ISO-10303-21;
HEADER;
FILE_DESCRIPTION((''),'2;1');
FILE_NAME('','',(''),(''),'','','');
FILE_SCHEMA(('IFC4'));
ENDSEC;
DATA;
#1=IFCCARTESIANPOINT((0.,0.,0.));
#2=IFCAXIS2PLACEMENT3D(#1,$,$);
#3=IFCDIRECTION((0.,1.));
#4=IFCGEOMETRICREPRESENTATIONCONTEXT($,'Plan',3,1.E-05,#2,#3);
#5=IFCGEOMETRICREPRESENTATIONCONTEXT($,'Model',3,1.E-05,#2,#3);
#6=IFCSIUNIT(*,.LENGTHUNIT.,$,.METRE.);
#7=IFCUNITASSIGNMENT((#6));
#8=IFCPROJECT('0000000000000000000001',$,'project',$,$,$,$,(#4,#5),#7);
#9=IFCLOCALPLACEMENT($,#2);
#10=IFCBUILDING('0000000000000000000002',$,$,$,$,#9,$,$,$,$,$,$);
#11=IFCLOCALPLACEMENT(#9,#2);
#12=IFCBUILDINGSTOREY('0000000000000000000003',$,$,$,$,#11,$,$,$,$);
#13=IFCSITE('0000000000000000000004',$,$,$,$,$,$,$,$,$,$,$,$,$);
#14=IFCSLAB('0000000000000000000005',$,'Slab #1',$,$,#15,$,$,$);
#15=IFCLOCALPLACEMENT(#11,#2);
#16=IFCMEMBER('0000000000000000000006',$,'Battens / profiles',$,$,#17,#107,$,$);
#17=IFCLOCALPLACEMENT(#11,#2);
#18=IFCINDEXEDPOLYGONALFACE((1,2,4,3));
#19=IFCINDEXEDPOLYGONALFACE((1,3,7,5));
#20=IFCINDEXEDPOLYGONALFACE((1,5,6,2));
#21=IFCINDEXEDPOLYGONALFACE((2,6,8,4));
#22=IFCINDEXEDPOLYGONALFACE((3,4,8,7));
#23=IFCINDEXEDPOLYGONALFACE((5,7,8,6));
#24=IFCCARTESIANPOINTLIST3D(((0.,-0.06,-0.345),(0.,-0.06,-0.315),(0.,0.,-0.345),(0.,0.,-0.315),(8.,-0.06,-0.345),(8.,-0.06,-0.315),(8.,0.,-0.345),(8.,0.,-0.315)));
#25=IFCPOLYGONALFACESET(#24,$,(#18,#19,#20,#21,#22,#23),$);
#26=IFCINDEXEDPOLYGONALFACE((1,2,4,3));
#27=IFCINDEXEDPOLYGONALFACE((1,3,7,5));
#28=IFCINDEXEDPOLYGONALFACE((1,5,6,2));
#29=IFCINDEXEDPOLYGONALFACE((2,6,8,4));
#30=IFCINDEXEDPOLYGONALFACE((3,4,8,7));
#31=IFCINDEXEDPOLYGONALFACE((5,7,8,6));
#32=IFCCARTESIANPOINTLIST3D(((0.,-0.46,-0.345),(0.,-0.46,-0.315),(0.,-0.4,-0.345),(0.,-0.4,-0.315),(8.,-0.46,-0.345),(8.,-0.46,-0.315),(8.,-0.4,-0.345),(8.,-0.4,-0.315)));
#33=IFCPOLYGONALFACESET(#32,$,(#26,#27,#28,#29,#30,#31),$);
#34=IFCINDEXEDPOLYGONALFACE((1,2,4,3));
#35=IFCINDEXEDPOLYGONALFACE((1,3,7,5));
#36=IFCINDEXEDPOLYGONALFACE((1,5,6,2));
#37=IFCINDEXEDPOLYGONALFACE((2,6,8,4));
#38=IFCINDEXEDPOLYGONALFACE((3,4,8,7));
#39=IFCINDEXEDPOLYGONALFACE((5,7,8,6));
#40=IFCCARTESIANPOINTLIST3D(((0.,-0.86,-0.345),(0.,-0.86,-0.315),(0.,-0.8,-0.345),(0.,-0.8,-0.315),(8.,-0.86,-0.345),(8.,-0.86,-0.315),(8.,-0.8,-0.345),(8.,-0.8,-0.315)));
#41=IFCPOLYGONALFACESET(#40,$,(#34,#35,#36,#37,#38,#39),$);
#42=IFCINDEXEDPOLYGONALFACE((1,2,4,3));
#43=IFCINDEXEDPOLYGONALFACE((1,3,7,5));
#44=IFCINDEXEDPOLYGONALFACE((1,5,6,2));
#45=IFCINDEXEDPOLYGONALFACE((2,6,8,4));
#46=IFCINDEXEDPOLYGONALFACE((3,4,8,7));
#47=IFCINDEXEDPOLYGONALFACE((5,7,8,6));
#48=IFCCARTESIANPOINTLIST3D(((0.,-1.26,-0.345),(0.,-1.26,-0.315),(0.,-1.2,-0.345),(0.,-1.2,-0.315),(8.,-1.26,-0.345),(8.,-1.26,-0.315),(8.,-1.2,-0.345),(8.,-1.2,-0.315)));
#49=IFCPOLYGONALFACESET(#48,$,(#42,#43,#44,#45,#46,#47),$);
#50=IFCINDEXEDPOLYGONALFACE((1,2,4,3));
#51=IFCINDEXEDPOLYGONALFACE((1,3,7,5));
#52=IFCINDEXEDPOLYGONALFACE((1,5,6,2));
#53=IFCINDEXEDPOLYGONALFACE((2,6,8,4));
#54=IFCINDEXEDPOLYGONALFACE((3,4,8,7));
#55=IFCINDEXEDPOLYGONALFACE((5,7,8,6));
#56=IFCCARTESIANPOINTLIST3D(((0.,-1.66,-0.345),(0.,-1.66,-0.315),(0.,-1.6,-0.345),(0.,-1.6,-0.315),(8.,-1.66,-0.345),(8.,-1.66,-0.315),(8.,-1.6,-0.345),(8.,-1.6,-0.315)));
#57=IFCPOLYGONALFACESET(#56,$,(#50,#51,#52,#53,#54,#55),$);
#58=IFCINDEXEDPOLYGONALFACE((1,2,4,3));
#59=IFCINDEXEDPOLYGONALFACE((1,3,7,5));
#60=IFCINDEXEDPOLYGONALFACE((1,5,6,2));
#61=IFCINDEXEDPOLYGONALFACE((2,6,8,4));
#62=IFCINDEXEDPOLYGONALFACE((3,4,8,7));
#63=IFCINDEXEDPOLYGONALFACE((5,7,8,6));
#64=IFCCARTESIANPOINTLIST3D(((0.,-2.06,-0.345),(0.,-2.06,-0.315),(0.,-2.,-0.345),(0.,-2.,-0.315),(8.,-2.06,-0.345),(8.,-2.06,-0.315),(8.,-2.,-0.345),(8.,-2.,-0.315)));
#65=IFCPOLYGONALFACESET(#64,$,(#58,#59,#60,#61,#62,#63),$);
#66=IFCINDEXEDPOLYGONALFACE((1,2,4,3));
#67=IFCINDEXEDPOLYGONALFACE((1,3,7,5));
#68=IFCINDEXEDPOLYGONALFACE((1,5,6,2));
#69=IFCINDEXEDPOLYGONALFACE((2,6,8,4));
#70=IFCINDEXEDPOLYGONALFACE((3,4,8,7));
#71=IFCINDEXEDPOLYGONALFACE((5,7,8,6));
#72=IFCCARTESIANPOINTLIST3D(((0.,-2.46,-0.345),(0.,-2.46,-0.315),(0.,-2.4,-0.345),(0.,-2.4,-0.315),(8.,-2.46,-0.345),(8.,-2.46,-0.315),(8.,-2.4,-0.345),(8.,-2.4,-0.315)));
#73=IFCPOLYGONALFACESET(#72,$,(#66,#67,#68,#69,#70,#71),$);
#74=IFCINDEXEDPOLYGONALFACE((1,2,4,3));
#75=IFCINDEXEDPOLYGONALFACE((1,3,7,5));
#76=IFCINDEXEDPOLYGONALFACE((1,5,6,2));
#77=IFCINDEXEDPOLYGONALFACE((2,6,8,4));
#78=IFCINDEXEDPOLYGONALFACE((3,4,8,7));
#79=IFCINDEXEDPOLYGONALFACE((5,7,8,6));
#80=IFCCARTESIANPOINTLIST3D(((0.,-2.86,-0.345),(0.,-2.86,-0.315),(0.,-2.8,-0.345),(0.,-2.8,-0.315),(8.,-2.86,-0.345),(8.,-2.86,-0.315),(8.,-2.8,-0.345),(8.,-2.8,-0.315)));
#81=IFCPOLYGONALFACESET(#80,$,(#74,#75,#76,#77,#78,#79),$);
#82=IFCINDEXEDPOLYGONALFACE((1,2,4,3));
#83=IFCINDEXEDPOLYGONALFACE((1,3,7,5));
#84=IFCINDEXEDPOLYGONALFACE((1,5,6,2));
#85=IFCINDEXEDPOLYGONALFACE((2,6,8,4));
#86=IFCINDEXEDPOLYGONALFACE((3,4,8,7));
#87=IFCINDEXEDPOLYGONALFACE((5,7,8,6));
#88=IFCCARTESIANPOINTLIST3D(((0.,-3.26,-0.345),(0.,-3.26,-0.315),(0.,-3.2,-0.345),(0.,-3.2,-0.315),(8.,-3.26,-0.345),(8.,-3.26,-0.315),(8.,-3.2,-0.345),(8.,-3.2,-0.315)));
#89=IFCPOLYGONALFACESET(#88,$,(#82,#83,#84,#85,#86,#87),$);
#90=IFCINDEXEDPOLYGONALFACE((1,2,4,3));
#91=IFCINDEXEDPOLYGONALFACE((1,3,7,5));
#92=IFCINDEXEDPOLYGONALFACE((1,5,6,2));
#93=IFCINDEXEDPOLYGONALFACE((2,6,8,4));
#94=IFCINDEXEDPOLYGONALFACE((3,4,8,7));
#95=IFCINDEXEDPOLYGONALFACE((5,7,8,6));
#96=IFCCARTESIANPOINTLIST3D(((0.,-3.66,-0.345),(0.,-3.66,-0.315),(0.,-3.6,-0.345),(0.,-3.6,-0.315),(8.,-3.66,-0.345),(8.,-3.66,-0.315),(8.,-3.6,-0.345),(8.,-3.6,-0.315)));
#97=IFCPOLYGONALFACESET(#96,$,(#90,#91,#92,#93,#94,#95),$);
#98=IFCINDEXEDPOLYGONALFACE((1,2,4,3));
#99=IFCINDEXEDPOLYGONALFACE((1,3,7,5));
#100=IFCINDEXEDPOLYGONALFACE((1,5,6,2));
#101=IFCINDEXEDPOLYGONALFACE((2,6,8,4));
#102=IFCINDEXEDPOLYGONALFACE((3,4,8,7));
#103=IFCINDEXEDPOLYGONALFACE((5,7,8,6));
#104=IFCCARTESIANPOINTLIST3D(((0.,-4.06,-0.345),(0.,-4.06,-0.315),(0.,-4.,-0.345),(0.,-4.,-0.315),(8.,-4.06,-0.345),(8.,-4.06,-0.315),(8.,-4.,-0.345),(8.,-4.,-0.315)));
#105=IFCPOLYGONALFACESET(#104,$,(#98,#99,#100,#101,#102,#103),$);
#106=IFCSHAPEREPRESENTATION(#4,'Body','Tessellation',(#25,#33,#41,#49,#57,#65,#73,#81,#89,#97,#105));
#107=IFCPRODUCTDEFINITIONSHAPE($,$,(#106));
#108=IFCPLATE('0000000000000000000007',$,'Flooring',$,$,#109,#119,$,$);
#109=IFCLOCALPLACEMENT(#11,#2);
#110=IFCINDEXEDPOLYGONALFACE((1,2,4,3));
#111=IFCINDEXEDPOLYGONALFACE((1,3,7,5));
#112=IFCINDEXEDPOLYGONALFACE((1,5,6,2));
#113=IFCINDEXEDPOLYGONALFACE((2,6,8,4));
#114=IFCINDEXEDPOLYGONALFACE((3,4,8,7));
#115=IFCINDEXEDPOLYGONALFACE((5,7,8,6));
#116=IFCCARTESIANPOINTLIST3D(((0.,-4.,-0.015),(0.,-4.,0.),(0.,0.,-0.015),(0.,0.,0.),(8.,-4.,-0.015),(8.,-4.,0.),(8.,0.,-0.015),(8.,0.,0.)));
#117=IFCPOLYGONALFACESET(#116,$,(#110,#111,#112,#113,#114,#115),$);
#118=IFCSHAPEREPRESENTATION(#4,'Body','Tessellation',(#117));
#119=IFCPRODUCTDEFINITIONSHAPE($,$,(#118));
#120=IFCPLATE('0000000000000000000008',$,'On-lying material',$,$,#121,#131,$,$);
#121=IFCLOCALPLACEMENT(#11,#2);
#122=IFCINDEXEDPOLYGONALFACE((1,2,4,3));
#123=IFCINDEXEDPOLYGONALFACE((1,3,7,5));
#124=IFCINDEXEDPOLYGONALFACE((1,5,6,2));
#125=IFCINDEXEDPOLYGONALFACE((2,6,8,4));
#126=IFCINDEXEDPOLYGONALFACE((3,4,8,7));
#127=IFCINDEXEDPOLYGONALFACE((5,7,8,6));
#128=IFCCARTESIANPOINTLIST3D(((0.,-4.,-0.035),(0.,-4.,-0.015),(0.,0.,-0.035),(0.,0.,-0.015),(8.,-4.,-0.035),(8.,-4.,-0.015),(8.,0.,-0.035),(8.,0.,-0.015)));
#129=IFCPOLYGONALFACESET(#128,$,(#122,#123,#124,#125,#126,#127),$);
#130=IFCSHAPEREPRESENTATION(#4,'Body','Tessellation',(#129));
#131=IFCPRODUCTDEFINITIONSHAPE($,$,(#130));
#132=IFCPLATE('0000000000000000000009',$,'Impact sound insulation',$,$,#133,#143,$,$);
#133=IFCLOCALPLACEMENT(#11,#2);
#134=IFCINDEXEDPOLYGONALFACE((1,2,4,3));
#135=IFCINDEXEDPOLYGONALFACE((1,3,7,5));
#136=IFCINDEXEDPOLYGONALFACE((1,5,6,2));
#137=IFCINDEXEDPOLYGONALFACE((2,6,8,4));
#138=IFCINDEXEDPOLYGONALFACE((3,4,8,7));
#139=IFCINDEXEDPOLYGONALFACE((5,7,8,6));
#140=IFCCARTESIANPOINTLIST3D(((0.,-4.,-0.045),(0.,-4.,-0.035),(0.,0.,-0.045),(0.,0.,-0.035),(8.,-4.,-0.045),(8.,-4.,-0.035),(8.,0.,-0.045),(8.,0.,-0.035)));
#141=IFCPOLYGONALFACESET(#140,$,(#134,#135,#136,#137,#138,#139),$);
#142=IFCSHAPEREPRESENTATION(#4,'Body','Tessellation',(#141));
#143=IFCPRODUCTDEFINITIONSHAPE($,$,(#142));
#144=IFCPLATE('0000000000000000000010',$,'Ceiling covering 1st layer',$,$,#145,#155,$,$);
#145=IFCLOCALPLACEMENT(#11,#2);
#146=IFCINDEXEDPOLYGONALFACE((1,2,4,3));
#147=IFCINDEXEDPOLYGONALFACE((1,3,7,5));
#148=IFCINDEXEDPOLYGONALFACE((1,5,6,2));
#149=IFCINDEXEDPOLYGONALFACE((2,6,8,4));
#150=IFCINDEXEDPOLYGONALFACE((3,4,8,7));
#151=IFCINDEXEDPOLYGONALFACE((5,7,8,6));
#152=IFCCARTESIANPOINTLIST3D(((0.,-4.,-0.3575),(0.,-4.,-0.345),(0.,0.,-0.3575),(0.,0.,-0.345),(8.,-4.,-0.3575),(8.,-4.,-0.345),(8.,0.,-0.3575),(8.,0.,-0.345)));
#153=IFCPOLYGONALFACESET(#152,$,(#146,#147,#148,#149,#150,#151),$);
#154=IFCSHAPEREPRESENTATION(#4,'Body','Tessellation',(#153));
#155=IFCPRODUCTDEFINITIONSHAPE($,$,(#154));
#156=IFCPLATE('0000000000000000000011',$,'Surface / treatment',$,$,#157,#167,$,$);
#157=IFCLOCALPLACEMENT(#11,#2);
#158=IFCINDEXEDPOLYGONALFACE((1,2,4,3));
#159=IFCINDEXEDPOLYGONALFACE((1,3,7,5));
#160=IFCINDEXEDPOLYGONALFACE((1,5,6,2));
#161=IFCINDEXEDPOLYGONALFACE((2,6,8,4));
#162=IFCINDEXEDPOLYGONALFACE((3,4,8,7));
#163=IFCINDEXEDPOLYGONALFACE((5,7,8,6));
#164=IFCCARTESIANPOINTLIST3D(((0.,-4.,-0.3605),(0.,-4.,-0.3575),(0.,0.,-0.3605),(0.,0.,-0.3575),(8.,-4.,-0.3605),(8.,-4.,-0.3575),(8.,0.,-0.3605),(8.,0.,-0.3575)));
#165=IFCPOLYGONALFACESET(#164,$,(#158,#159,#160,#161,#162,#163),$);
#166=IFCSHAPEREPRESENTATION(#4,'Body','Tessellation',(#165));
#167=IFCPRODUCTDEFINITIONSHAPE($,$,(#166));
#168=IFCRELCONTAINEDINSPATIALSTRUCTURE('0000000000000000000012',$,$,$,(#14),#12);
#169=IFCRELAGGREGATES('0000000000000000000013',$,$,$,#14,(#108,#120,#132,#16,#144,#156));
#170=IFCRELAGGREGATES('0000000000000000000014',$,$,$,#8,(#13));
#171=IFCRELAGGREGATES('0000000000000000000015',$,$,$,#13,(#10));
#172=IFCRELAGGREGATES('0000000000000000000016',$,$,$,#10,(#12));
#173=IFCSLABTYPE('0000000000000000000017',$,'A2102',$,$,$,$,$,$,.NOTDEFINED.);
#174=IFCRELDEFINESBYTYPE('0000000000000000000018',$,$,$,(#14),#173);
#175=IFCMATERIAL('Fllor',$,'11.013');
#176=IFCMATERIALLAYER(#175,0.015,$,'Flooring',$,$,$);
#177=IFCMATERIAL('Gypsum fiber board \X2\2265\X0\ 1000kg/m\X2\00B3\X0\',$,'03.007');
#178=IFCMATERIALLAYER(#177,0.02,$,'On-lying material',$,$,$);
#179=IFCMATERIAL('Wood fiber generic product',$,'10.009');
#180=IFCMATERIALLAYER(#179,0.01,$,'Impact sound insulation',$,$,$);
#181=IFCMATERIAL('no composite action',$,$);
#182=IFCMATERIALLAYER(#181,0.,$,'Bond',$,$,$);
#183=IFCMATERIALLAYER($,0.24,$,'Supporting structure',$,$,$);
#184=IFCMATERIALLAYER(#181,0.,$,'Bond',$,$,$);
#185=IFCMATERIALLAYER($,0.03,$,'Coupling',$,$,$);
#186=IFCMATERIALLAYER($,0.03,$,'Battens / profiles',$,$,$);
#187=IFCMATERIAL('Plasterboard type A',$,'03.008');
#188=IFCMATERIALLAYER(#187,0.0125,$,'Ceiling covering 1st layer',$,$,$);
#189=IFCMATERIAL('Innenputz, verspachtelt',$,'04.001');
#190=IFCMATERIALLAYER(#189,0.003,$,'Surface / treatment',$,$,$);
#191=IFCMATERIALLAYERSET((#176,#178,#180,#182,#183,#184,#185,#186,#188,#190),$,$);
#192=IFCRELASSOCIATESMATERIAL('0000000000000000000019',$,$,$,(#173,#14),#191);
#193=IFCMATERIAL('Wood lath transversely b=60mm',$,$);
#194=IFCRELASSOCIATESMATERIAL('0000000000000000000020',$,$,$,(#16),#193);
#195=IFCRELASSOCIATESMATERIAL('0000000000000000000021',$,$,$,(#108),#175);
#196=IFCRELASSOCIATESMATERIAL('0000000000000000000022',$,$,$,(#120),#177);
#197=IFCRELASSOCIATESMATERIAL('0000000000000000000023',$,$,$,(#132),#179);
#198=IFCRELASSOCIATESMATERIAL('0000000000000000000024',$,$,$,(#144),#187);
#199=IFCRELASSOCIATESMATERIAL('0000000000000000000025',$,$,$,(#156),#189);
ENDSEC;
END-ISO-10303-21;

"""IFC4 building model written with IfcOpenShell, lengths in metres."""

from ifc_helpers import new_model, si_unit, direction, frame, frame_2d, origin, origin_with_axes, place, context, project, spatial, rectangle, extrude, material, layer, layer_set, type_object, element, aggregate, save


model = new_model("IFC4")

# Units and contexts
plan_context = context("Plan", 3, precision=1e-05, world=origin(), true_north=direction((0.0, 1.0)))
model_context = context("Model", 3, precision=1e-05, world=origin(), true_north=direction((0.0, 1.0)))
ifc_project = project(units=[si_unit("LENGTHUNIT", "METRE")], contexts=[plan_context, model_context])

# Site, building, storey
site = spatial("IfcSite", under=ifc_project)
building_placement = place(None, origin())
building = spatial("IfcBuilding", under=site, at=building_placement)
storey_placement = place(building_placement, origin())
storey = spatial("IfcBuildingStorey", under=building, at=storey_placement)

# Slab, member, plates
ifc_material_1 = material(Name="Fllor", Category="11.013")
ifc_layer_1 = layer(ifc_material_1, 0.015, Name="Flooring")
ifc_material_2 = material(Name="Gypsum fiber board ≥ 1000kg/m³", Category="03.007")
ifc_layer_2 = layer(ifc_material_2, 0.02, Name="On-lying material")
ifc_material_3 = material(Name="Wood fiber generic product", Category="10.009")
ifc_layer_3 = layer(ifc_material_3, 0.01, Name="Impact sound insulation")
ifc_material_4 = material(Name="no composite action")
ifc_layer_4 = layer(ifc_material_4, 0.0, Name="Bond")
ifc_layer_5 = layer(None, 0.24, Name="Supporting structure")
ifc_layer_6 = layer(ifc_material_4, 0.0, Name="Bond")
ifc_layer_7 = layer(None, 0.03, Name="Coupling")
ifc_layer_8 = layer(None, 0.03, Name="Battens / profiles")
ifc_material_5 = material(Name="Plasterboard type A", Category="03.008")
ifc_layer_9 = layer(ifc_material_5, 0.0125, Name="Ceiling covering 1st layer")
ifc_material_6 = material(Name="Innenputz, verspachtelt", Category="04.001")
ifc_layer_10 = layer(ifc_material_6, 0.003, Name="Surface / treatment")
ifc_layer_set = layer_set([ifc_layer_1, ifc_layer_2, ifc_layer_3, ifc_layer_4, ifc_layer_5, ifc_layer_6, ifc_layer_7, ifc_layer_8, ifc_layer_9, ifc_layer_10])
slab_type = type_object("IfcSlabType", Name="A2102", PredefinedType="NOTDEFINED", material=ifc_layer_set)
slab_placement = place(None, frame((0.0, 0.0, 0.0), z_axis=(0.0, 0.0, -1.0), x_axis=(1.0, 0.0, 0.0)))
slab = element("IfcSlab", 1, at=slab_placement, inside=storey, type_object=slab_type, material=ifc_layer_set, Name="Slab #1")
ifc_material_7 = material(Name="Wood lath transversely b=60mm")
member_1_placement = place(slab_placement, origin())
member_1 = element("IfcMember", 2, at=member_1_placement, material=ifc_material_7, Name="Battens / profiles", context=plan_context, shape_type="SweptSolid", body=[
    extrude(rectangle(XDim=0.06, YDim=0.03, at=frame_2d((0.03, 0.015), x_axis=(1.0, 0.0))), frame((0.0, 0.0, 0.315), z_axis=(1.0, 0.0, 0.0), x_axis=(0.0, 1.0, 0.0)), (0.0, 0.0, 1.0), 8.0),
    extrude(rectangle(XDim=0.06, YDim=0.03, at=frame_2d((0.03, 0.015), x_axis=(1.0, 0.0))), frame((0.0, 0.4, 0.315), z_axis=(1.0, 0.0, 0.0), x_axis=(0.0, 1.0, 0.0)), (0.0, 0.0, 1.0), 8.0),
    extrude(rectangle(XDim=0.06, YDim=0.03, at=frame_2d((0.03, 0.015), x_axis=(1.0, 0.0))), frame((0.0, 0.8, 0.315), z_axis=(1.0, 0.0, 0.0), x_axis=(0.0, 1.0, 0.0)), (0.0, 0.0, 1.0), 8.0),
    extrude(rectangle(XDim=0.06, YDim=0.03, at=frame_2d((0.03, 0.015), x_axis=(1.0, 0.0))), frame((0.0, 1.2, 0.315), z_axis=(1.0, 0.0, 0.0), x_axis=(0.0, 1.0, 0.0)), (0.0, 0.0, 1.0), 8.0),
    extrude(rectangle(XDim=0.06, YDim=0.03, at=frame_2d((0.03, 0.015), x_axis=(1.0, 0.0))), frame((0.0, 1.6, 0.315), z_axis=(1.0, 0.0, 0.0), x_axis=(0.0, 1.0, 0.0)), (0.0, 0.0, 1.0), 8.0),
    extrude(rectangle(XDim=0.06, YDim=0.03, at=frame_2d((0.03, 0.015), x_axis=(1.0, 0.0))), frame((0.0, 2.0, 0.315), z_axis=(1.0, 0.0, 0.0), x_axis=(0.0, 1.0, 0.0)), (0.0, 0.0, 1.0), 8.0),
    extrude(rectangle(XDim=0.06, YDim=0.03, at=frame_2d((0.03, 0.015), x_axis=(1.0, 0.0))), frame((0.0, 2.4, 0.315), z_axis=(1.0, 0.0, 0.0), x_axis=(0.0, 1.0, 0.0)), (0.0, 0.0, 1.0), 8.0),
    extrude(rectangle(XDim=0.06, YDim=0.03, at=frame_2d((0.03, 0.015), x_axis=(1.0, 0.0))), frame((0.0, 2.8, 0.315), z_axis=(1.0, 0.0, 0.0), x_axis=(0.0, 1.0, 0.0)), (0.0, 0.0, 1.0), 8.0),
    extrude(rectangle(XDim=0.06, YDim=0.03, at=frame_2d((0.03, 0.015), x_axis=(1.0, 0.0))), frame((0.0, 3.2, 0.315), z_axis=(1.0, 0.0, 0.0), x_axis=(0.0, 1.0, 0.0)), (0.0, 0.0, 1.0), 8.0),
    extrude(rectangle(XDim=0.06, YDim=0.03, at=frame_2d((0.03, 0.015), x_axis=(1.0, 0.0))), frame((0.0, 3.6, 0.315), z_axis=(1.0, 0.0, 0.0), x_axis=(0.0, 1.0, 0.0)), (0.0, 0.0, 1.0), 8.0),
    extrude(rectangle(XDim=0.06, YDim=0.03, at=frame_2d((0.03, 0.015), x_axis=(1.0, 0.0))), frame((0.0, 4.0, 0.315), z_axis=(1.0, 0.0, 0.0), x_axis=(0.0, 1.0, 0.0)), (0.0, 0.0, 1.0), 8.0),
])
plate_1_placement = place(slab_placement, origin())
plate_1 = element("IfcPlate", 3, at=plate_1_placement, material=ifc_material_1, Name="Flooring", context=plan_context, shape_type="SweptSolid", body=[
    extrude(rectangle(XDim=8.0, YDim=4.0, at=frame_2d((4.0, 2.0), x_axis=(1.0, 0.0))), origin_with_axes(), (0.0, 0.0, 1.0), 0.015),
])
plate_2_placement = place(slab_placement, origin())
plate_2 = element("IfcPlate", 4, at=plate_2_placement, material=ifc_material_2, Name="On-lying material", context=plan_context, shape_type="SweptSolid", body=[
    extrude(rectangle(XDim=8.0, YDim=4.0, at=frame_2d((4.0, 2.0), x_axis=(1.0, 0.0))), frame((0.0, 0.0, 0.015), z_axis=(0.0, 0.0, 1.0), x_axis=(1.0, 0.0, 0.0)), (0.0, 0.0, 1.0), 0.02),
])
plate_3_placement = place(slab_placement, origin())
plate_3 = element("IfcPlate", 5, at=plate_3_placement, material=ifc_material_3, Name="Impact sound insulation", context=plan_context, shape_type="SweptSolid", body=[
    extrude(rectangle(XDim=8.0, YDim=4.0, at=frame_2d((4.0, 2.0), x_axis=(1.0, 0.0))), frame((0.0, 0.0, 0.035), z_axis=(0.0, 0.0, 1.0), x_axis=(1.0, 0.0, 0.0)), (0.0, 0.0, 1.0), 0.01),
])
plate_4_placement = place(slab_placement, origin())
plate_4 = element("IfcPlate", 6, at=plate_4_placement, material=ifc_material_5, Name="Ceiling covering 1st layer", context=plan_context, shape_type="SweptSolid", body=[
    extrude(rectangle(XDim=8.0, YDim=4.0, at=frame_2d((4.0, 2.0), x_axis=(1.0, 0.0))), frame((0.0, 0.0, 0.345), z_axis=(0.0, 0.0, 1.0), x_axis=(1.0, 0.0, 0.0)), (0.0, 0.0, 1.0), 0.0125),
])
plate_5_placement = place(slab_placement, origin())
plate_5 = element("IfcPlate", 7, at=plate_5_placement, material=ifc_material_6, Name="Surface / treatment", context=plan_context, shape_type="SweptSolid", body=[
    extrude(rectangle(XDim=8.0, YDim=4.0, at=frame_2d((4.0, 2.0), x_axis=(1.0, 0.0))), frame((0.0, 0.0, 0.3575), z_axis=(0.0, 0.0, 1.0), x_axis=(1.0, 0.0, 0.0)), (0.0, 0.0, 1.0), 0.003),
])
aggregate(slab, [plate_1, plate_2, plate_3, member_1, plate_4, plate_5])

save(model, "model.ifc")
